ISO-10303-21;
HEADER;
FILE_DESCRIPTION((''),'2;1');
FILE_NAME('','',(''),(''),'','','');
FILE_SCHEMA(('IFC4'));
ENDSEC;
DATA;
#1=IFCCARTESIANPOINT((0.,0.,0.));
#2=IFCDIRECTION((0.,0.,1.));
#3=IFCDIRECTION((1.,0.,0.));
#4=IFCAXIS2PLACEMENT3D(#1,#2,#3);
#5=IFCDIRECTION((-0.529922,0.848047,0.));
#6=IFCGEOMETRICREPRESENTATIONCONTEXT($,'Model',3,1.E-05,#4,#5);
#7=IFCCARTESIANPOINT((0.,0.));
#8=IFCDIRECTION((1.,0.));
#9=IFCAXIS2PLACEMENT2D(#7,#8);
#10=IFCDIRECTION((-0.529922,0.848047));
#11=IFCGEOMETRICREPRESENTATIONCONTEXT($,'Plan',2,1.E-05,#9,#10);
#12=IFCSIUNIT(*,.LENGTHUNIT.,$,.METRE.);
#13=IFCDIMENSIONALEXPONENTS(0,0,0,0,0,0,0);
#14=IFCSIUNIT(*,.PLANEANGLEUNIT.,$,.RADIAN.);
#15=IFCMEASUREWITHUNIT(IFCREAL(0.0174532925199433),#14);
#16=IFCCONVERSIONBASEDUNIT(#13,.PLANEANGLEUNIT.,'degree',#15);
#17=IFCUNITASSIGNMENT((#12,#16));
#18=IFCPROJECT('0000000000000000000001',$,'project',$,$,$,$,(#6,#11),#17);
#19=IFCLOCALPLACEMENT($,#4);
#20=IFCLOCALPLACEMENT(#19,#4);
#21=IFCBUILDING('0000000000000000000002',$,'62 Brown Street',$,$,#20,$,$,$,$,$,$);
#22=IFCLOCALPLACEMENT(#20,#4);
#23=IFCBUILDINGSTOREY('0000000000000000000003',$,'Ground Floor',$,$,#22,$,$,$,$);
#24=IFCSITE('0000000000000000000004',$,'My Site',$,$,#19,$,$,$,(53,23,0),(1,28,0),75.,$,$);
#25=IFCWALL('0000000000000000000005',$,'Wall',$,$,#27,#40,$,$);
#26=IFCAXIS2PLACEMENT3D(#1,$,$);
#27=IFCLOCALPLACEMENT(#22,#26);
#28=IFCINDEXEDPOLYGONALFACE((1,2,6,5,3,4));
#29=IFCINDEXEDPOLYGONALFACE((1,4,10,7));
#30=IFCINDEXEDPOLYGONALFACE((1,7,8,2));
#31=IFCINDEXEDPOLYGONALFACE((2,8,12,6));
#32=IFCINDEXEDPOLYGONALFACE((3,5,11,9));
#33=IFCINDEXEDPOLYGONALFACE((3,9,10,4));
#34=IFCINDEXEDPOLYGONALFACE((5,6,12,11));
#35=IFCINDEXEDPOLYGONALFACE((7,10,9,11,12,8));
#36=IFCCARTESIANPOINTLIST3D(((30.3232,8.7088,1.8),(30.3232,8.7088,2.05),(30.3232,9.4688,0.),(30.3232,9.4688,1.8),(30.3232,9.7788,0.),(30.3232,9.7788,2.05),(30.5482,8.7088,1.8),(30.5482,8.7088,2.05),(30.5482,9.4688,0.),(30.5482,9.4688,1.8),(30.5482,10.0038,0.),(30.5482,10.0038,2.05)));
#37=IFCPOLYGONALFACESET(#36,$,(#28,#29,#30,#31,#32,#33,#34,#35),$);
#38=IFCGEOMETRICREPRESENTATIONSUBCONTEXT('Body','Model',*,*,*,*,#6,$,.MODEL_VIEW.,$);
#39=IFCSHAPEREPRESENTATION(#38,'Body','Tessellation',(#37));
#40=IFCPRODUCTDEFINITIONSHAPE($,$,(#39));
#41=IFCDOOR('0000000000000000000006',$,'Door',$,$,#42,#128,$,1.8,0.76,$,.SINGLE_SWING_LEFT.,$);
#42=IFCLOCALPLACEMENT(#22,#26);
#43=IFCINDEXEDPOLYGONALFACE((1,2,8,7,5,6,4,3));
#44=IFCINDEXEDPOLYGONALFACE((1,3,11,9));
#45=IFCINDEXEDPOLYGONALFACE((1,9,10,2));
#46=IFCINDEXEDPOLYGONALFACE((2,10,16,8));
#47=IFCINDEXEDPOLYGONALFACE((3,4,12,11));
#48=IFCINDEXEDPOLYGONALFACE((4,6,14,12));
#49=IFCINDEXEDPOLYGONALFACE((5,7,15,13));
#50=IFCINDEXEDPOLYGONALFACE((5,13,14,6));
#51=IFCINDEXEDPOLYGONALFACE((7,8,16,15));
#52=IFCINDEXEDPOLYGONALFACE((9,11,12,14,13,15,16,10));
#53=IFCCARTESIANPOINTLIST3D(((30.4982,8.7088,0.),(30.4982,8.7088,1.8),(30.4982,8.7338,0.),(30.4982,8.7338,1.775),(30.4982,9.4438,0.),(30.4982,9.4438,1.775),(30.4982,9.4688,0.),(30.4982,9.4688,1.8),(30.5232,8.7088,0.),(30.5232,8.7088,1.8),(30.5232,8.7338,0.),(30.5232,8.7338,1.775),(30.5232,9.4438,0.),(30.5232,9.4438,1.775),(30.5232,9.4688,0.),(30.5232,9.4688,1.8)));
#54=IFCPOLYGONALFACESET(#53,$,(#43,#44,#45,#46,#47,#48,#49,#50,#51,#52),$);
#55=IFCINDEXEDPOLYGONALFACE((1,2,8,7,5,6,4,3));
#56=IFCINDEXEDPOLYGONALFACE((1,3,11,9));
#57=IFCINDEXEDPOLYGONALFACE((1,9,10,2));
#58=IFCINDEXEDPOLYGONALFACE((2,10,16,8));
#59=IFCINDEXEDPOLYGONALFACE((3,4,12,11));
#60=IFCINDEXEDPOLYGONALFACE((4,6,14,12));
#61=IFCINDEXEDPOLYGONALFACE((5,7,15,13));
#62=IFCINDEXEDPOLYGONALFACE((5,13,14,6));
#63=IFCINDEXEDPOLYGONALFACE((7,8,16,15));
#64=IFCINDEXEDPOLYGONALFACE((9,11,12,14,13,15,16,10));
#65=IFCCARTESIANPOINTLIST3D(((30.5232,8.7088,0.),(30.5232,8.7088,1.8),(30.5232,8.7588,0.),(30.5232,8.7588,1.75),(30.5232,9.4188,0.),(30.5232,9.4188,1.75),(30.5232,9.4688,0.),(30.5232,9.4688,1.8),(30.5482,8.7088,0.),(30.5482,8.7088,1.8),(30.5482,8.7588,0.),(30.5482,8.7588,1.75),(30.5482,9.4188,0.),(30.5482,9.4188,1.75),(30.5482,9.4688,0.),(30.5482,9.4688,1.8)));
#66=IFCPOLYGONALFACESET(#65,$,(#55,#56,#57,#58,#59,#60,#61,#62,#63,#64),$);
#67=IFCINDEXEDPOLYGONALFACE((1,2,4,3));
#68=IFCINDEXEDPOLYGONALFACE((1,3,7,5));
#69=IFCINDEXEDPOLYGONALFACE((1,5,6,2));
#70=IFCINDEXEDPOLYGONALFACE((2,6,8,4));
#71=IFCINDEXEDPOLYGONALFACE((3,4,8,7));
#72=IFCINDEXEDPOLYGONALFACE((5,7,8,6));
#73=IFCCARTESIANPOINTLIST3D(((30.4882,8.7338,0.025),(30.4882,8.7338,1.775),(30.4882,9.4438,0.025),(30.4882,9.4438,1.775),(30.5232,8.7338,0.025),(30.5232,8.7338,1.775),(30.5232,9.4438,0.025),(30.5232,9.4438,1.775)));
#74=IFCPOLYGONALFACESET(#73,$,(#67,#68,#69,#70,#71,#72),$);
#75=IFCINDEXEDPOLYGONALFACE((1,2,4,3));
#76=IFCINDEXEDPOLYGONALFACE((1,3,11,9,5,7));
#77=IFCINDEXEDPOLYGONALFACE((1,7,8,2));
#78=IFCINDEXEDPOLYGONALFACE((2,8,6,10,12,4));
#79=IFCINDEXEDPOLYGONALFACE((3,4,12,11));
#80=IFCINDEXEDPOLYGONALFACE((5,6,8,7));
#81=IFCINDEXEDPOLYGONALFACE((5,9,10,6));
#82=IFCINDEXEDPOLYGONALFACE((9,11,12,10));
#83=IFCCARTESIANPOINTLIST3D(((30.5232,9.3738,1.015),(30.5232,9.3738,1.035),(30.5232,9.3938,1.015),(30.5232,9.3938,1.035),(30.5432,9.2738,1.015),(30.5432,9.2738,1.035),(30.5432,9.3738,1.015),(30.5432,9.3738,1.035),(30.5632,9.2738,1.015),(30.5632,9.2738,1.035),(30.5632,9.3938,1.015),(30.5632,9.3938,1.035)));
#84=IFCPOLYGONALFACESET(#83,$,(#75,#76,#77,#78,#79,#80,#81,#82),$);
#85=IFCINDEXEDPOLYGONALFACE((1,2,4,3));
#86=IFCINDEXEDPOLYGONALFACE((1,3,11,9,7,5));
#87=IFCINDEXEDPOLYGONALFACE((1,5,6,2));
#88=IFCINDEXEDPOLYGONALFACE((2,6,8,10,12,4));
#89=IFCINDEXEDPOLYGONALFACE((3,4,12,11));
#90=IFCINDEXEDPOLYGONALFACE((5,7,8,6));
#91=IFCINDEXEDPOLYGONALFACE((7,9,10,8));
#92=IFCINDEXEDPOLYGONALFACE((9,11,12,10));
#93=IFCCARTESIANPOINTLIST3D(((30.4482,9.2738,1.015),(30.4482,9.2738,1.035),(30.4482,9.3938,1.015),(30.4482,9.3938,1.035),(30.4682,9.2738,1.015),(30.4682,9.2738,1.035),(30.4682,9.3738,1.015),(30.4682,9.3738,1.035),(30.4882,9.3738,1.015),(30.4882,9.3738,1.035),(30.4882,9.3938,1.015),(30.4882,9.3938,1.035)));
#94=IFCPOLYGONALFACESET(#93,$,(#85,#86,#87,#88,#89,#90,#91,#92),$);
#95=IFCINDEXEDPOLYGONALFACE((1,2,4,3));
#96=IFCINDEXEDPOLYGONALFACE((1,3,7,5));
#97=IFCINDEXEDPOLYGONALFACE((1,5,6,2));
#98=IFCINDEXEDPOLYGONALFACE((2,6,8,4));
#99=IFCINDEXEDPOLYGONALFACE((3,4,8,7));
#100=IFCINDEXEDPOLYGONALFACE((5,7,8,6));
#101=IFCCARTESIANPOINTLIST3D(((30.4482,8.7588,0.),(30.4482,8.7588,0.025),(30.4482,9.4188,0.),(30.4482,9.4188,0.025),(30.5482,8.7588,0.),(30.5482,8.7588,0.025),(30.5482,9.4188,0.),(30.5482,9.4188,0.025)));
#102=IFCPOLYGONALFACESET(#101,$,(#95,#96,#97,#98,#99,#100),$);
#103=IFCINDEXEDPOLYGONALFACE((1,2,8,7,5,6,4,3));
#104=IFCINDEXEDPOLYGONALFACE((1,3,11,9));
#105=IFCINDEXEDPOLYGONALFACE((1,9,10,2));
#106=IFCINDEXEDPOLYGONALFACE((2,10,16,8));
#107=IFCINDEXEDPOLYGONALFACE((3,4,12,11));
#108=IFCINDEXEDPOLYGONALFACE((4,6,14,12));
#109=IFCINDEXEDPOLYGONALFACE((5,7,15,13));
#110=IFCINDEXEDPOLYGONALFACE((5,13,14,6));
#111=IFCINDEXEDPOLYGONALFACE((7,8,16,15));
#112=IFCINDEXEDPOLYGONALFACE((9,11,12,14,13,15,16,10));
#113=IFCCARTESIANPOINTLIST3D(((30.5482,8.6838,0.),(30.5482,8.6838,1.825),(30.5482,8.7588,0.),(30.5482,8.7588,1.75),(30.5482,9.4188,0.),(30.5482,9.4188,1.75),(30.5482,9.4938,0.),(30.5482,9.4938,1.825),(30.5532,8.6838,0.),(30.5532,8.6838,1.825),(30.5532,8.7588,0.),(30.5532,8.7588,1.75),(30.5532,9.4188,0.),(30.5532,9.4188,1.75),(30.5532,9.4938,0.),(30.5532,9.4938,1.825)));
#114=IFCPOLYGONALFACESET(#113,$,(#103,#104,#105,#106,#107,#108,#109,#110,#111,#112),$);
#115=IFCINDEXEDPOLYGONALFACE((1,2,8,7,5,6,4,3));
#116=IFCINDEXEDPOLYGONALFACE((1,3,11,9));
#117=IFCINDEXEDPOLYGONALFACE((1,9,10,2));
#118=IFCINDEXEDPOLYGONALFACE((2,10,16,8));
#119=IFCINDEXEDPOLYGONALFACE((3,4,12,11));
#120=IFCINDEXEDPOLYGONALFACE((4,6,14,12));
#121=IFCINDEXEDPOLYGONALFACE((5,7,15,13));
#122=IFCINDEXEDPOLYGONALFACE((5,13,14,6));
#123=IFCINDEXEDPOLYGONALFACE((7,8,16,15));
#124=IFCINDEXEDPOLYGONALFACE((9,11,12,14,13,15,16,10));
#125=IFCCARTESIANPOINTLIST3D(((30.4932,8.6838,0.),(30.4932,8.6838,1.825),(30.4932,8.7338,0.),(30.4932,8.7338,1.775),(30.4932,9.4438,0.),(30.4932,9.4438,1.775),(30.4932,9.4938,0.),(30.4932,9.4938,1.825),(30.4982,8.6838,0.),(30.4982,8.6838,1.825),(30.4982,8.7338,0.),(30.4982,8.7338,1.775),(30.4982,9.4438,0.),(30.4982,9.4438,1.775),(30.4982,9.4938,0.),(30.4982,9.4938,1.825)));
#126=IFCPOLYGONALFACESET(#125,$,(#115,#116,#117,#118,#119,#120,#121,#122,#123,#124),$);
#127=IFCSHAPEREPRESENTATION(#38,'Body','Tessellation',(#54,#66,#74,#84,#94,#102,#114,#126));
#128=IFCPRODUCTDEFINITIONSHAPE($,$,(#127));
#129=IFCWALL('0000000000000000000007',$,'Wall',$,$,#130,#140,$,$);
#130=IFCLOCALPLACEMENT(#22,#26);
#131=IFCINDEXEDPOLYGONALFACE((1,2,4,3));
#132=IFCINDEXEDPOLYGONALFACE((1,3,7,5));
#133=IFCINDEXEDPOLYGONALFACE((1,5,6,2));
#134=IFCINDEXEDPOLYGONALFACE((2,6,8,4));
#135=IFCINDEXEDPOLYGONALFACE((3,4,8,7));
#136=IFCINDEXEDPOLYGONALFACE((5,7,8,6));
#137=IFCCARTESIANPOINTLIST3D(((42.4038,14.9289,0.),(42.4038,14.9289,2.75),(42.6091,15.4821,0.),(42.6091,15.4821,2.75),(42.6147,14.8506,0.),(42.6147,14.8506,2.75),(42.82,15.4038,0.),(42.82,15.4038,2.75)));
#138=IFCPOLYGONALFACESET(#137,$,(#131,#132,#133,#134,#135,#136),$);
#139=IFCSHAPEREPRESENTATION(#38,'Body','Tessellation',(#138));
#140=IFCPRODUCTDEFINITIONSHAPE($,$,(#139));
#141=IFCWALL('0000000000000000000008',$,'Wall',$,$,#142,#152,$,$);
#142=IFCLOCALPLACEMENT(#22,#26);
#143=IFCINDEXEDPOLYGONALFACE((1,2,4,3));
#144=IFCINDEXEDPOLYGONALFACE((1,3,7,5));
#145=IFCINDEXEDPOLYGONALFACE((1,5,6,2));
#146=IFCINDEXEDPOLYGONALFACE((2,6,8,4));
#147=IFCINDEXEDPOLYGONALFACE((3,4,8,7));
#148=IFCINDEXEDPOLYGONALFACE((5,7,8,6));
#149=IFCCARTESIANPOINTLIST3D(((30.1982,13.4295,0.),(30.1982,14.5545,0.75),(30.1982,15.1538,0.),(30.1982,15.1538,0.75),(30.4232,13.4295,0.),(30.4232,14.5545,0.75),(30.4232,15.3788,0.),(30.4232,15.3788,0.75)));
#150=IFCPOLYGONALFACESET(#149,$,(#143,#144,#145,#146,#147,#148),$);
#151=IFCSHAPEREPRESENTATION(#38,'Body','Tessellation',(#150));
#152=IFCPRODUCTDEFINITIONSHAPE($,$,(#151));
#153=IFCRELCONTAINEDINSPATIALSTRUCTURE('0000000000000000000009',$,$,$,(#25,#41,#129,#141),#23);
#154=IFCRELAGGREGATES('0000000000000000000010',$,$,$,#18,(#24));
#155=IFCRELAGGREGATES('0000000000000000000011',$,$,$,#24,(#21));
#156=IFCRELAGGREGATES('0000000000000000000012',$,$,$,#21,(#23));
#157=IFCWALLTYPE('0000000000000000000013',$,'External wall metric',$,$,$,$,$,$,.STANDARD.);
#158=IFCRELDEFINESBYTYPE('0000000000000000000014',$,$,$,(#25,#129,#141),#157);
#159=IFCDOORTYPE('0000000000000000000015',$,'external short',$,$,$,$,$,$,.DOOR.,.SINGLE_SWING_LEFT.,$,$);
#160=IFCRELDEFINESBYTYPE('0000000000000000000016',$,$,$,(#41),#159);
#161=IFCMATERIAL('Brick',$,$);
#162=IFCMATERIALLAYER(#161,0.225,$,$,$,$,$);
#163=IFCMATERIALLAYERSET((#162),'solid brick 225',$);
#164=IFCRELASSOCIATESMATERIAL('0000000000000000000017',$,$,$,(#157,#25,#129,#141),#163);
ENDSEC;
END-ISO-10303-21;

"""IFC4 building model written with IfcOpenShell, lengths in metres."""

from ifc_helpers import new_model, entity, si_unit, converted_unit, direction, frame, origin_with_axes, origin_2d_with_axis, place, context, subcontext, project, spatial, line, indexed_curve, outline, extrude, clip, halfspace, shape, source, transform, mapped, material, layer, layer_set, layer_usage, type_object, type_shapes, element, fill, save


model = new_model("IFC4")

# Units and contexts
model_context = context("Model", 3, precision=1e-05, world=origin_with_axes(), true_north=direction((-0.529922, 0.848047, 0.0)))
plan_context = context("Plan", 2, precision=1e-05, world=origin_2d_with_axis(), true_north=direction((-0.529922, 0.848047)))
body_context_1 = subcontext(model_context, "Body", "Model", "MODEL_VIEW")
body_context_2 = subcontext(plan_context, "Body", "Plan", "PLAN_VIEW")
ifc_project = project(units=[si_unit("LENGTHUNIT", "METRE"), converted_unit("PLANEANGLEUNIT", "degree", entity("IfcReal", 0.0174532925199433), si_unit("PLANEANGLEUNIT", "RADIAN"), dimensions=[0, 0, 0, 0, 0, 0, 0])], contexts=[model_context, plan_context])

# Site, building, storey
site_placement = place(None, origin_with_axes())
site = spatial("IfcSite", under=ifc_project, at=site_placement, Name="My Site", RefLatitude=(53, 23, 0), RefLongitude=(1, 28, 0), RefElevation=75.0)
building_placement = place(site_placement, origin_with_axes())
building = spatial("IfcBuilding", under=site, at=building_placement, Name="62 Brown Street")
storey_placement = place(building_placement, origin_with_axes())
storey = spatial("IfcBuildingStorey", under=building, at=storey_placement, Name="Ground Floor")

# Shared definitions
ifc_material_1 = material(Name="Brick")
ifc_layer_1 = layer(ifc_material_1, 0.225)
ifc_layer_set_1 = layer_set([ifc_layer_1], Name="solid brick 225")
wall_type_1 = type_object("IfcWallType", Name="External wall metric", PredefinedType="STANDARD", material=ifc_layer_set_1)

# Wall, opening, door
ifc_layer_usage_1 = layer_usage(ifc_layer_set_1, "AXIS2", "POSITIVE", 0.0)
wall_1_placement = place(storey_placement, frame((30.5482, 8.7088, 0.0), z_axis=(0.0, 0.0, 1.0), x_axis=(0.0, 1.0, 0.0)))
wall_1 = element("IfcWall", 1, at=wall_1_placement, inside=storey, type_object=wall_type_1, material=ifc_layer_usage_1, Name="Wall", context=body_context_1, shape_type="Clipping", body=[
    clip(extrude(outline(indexed_curve([(0.0, 0.0), (0.0, 0.225), (1.295, 0.225), (1.295, 0.0), (0.0, 0.0)], self_intersect=False)), origin_with_axes(), (0.0, 0.0, 1.0), 2.05), halfspace(frame((1.295, 0.0, 0.0), z_axis=(0.450001, 0.450001, 0.0), x_axis=(-0.225, 0.225, 0.0)), False)),
])
shared_shape_1 = source(origin_with_axes(), body_context_1, "Body", "SweptSolid", [
    extrude(outline(indexed_curve([(0.0, 0.0), (0.76, 0.0), (0.76, 1.8), (0.0, 1.8)], segments=[line(1, 2, 3, 4, 1)])), frame((0.0, -0.1, 0.0), z_axis=(0.0, -1.0, 0.0), x_axis=(1.0, 0.0, 0.0)), (0.0, 0.0, -1.0), 0.425),
])
opening_1_placement = place(wall_1_placement, frame((0.0, 0.0, 0.0), z_axis=(0.0, 0.0, 1.0), x_axis=(1.0, 0.0, 0.0)))
opening_1 = element("IfcOpeningElement", 2, at=opening_1_placement, cuts=wall_1, PredefinedType="OPENING", context=body_context_1, shape_type="MappedRepresentation", body=[
    mapped(shared_shape_1, transform((0.0, 0.0, 0.0), x_axis=(1.0, 0.0, 0.0), y_axis=(0.0, 1.0, 0.0), z_axis=(0.0, 0.0, 1.0), scale=1.0)),
])
door_type_1 = type_object("IfcDoorType", Name="external short", OperationType="SINGLE_SWING_LEFT", PredefinedType="DOOR")
shared_shape_2 = source(origin_with_axes(), body_context_1, "Body", "SweptSolid", [
    extrude(outline(indexed_curve([(0.0, 0.0), (0.0, 1.8), (0.76, 1.8), (0.76, 0.0), (0.735, 0.0), (0.735, 1.775), (0.025, 1.775), (0.025, 0.0)], segments=[line(1, 2, 3, 4, 5, 6, 7, 8, 1)])), frame((0.0, 0.025, 0.0), z_axis=(0.0, -1.0, 0.0), x_axis=(1.0, 0.0, 0.0)), (0.0, 0.0, -1.0), 0.025),
    extrude(outline(indexed_curve([(0.0, 0.0), (0.0, 1.8), (0.76, 1.8), (0.76, 0.0), (0.71, 0.0), (0.71, 1.75), (0.05, 1.75), (0.05, 0.0)], segments=[line(1, 2, 3, 4, 5, 6, 7, 8, 1)])), frame((0.0, 0.0, 0.0), z_axis=(0.0, -1.0, 0.0), x_axis=(1.0, 0.0, 0.0)), (0.0, 0.0, -1.0), 0.025),
    extrude(outline(indexed_curve([(0.0, 0.0), (0.71, 0.0), (0.71, 0.035), (0.0, 0.035)], segments=[line(1, 2, 3, 4, 1)])), frame((0.025, 0.025, 0.025), z_axis=(0.0, 0.0, 1.0), x_axis=(1.0, 0.0, 0.0)), (0.0, 0.0, 1.0), 1.75),
    extrude(outline(indexed_curve([(0.0, 0.0), (0.0, -0.04), (-0.12, -0.04), (-0.12, -0.02), (-0.02, -0.02), (-0.02, 0.0)], segments=[line(1, 2, 3, 4, 5, 6, 1)])), frame((0.685, 0.025, 1.015), z_axis=(0.0, 0.0, 1.0), x_axis=(1.0, 0.0, 0.0)), (0.0, 0.0, 1.0), 0.02),
    extrude(outline(indexed_curve([(0.0, 0.0), (0.0, 0.04), (-0.12, 0.04), (-0.12, 0.02), (-0.02, 0.02), (-0.02, 0.0)], segments=[line(1, 2, 3, 4, 5, 6, 1)])), frame((0.685, 0.06, 1.015), z_axis=(0.0, 0.0, 1.0), x_axis=(1.0, 0.0, 0.0)), (0.0, 0.0, 1.0), 0.02),
    extrude(outline(indexed_curve([(0.0, 0.0), (0.66, 0.0), (0.66, 0.1), (0.0, 0.1)], segments=[line(1, 2, 3, 4, 1)])), frame((0.05, 0.0, 0.0), z_axis=(0.0, 0.0, 1.0), x_axis=(1.0, 0.0, 0.0)), (0.0, 0.0, 1.0), 0.025),
    extrude(outline(indexed_curve([(0.0, 0.0), (0.0, 1.825), (0.81, 1.825), (0.81, 0.0), (0.735, 0.0), (0.735, 1.75), (0.075, 1.75), (0.075, 0.0)], segments=[line(1, 2, 3, 4, 5, 6, 7, 8, 1)])), frame((-0.025, -0.005, 0.0), z_axis=(0.0, -1.0, 0.0), x_axis=(1.0, 0.0, 0.0)), (0.0, 0.0, -1.0), 0.005),
    extrude(outline(indexed_curve([(0.0, 0.0), (0.0, 1.825), (0.81, 1.825), (0.81, 0.0), (0.76, 0.0), (0.76, 1.775), (0.05, 1.775), (0.05, 0.0)], segments=[line(1, 2, 3, 4, 5, 6, 7, 8, 1)])), frame((-0.025, 0.05, 0.0), z_axis=(0.0, -1.0, 0.0), x_axis=(1.0, 0.0, 0.0)), (0.0, 0.0, -1.0), 0.005),
])
shared_shape_3 = source(origin_with_axes(), body_context_2, "Body", "Curve2D", [
    entity("IfcIndexedPolyCurve", entity("IfcCartesianPointList2D", [[0.0, 0.0], [0.0, 0.05], [0.025, 0.05], [0.025, 0.025], [0.05, 0.025], [0.05, 0.0]]), [entity("IfcLineIndex", [1, 2, 3, 4, 5, 6, 1])]),
    entity("IfcIndexedPolyCurve", entity("IfcCartesianPointList2D", [[0.76, 0.0], [0.76, 0.05], [0.735, 0.05], [0.735, 0.025], [0.71, 0.025], [0.71, 0.0]]), [entity("IfcLineIndex", [1, 2, 3, 4, 5, 6, 1])]),
    entity("IfcTrimmedCurve", entity("IfcEllipse", entity("IfcAxis2Placement2D", entity("IfcCartesianPoint", [0.06, 0.05]), entity("IfcDirection", [1.0, 0.0])), 0.675, 0.71), [entity("IfcCartesianPoint", [0.735, 0.05])], [entity("IfcCartesianPoint", [0.06, 0.76])], True, "CARTESIAN"),
    entity("IfcIndexedPolyCurve", entity("IfcCartesianPointList2D", [[0.025, 0.05], [0.06, 0.05], [0.06, 0.76], [0.025, 0.76]]), [entity("IfcLineIndex", [1, 2, 3, 4, 1])]),
])
type_shapes(door_type_1, [shared_shape_2, shared_shape_3])
door_1_placement = place(opening_1_placement, frame((0.0, 0.0, 0.0), z_axis=(0.0, 0.0, 1.0), x_axis=(1.0, 0.0, 0.0)))
door_1 = element("IfcDoor", 3, at=door_1_placement, inside=storey, type_object=door_type_1, Name="Door", OperationType="SINGLE_SWING_LEFT", OverallHeight=1.8, OverallWidth=0.76, shapes=[
    shape(body_context_1, "Body", "MappedRepresentation", [mapped(shared_shape_2, transform((0.0, 0.0, 0.0), x_axis=(1.0, 0.0, 0.0), y_axis=(0.0, 1.0, 0.0), z_axis=(0.0, 0.0, 1.0), scale=1.0))]),
    shape(body_context_2, "Body", "MappedRepresentation", [mapped(shared_shape_3, transform((0.0, 0.0, 0.0), x_axis=(1.0, 0.0, 0.0), y_axis=(0.0, 1.0, 0.0), z_axis=(0.0, 0.0, 1.0), scale=1.0))]),
])
fill(opening_1, door_1)

# Walls
ifc_layer_usage_2 = layer_usage(ifc_layer_set_1, "AXIS2", "POSITIVE", 0.0)
wall_2_placement = place(storey_placement, frame((42.6147, 14.8506, 0.0), z_axis=(0.0, 0.0, 1.0), x_axis=(0.347944, 0.937515, 0.0)))
element("IfcWall", 4, at=wall_2_placement, inside=storey, type_object=wall_type_1, material=ifc_layer_usage_2, Name="Wall", context=body_context_1, shape_type="SweptSolid", body=[
    extrude(outline(indexed_curve([(0.0, 0.0), (0.0, 0.225), (0.5901, 0.225), (0.5901, 0.0), (0.0, 0.0)], self_intersect=False)), origin_with_axes(), (0.0, 0.0, 1.0), 2.75),
])
ifc_layer_usage_3 = layer_usage(ifc_layer_set_1, "AXIS2", "POSITIVE", 0.0)
wall_3_placement = place(storey_placement, frame((30.4232, 13.4295, 0.0), z_axis=(0.0, 0.0, 1.0), x_axis=(0.0, 1.0, 0.0)))
element("IfcWall", 5, at=wall_3_placement, inside=storey, type_object=wall_type_1, material=ifc_layer_usage_3, Name="Wall", context=body_context_1, shape_type="Clipping", body=[
    clip(clip(extrude(outline(indexed_curve([(0.0, 0.0), (0.0, 0.225), (1.9493, 0.225), (1.9493, 0.0), (0.0, 0.0)], self_intersect=False)), origin_with_axes(), (0.0, 0.0, 1.0), 0.75), halfspace(frame((0.416, 0.5, 0.2774), z_axis=(-0.5547, 0.0, 0.83205), x_axis=(0.0, -1.0, 0.0)), False)), halfspace(frame((1.9493, 0.0, 0.0), z_axis=(0.707107, 0.707107, 0.0), x_axis=(0.707107, -0.707107, 0.0)), False)),
])

save(model, "model.ifc")
